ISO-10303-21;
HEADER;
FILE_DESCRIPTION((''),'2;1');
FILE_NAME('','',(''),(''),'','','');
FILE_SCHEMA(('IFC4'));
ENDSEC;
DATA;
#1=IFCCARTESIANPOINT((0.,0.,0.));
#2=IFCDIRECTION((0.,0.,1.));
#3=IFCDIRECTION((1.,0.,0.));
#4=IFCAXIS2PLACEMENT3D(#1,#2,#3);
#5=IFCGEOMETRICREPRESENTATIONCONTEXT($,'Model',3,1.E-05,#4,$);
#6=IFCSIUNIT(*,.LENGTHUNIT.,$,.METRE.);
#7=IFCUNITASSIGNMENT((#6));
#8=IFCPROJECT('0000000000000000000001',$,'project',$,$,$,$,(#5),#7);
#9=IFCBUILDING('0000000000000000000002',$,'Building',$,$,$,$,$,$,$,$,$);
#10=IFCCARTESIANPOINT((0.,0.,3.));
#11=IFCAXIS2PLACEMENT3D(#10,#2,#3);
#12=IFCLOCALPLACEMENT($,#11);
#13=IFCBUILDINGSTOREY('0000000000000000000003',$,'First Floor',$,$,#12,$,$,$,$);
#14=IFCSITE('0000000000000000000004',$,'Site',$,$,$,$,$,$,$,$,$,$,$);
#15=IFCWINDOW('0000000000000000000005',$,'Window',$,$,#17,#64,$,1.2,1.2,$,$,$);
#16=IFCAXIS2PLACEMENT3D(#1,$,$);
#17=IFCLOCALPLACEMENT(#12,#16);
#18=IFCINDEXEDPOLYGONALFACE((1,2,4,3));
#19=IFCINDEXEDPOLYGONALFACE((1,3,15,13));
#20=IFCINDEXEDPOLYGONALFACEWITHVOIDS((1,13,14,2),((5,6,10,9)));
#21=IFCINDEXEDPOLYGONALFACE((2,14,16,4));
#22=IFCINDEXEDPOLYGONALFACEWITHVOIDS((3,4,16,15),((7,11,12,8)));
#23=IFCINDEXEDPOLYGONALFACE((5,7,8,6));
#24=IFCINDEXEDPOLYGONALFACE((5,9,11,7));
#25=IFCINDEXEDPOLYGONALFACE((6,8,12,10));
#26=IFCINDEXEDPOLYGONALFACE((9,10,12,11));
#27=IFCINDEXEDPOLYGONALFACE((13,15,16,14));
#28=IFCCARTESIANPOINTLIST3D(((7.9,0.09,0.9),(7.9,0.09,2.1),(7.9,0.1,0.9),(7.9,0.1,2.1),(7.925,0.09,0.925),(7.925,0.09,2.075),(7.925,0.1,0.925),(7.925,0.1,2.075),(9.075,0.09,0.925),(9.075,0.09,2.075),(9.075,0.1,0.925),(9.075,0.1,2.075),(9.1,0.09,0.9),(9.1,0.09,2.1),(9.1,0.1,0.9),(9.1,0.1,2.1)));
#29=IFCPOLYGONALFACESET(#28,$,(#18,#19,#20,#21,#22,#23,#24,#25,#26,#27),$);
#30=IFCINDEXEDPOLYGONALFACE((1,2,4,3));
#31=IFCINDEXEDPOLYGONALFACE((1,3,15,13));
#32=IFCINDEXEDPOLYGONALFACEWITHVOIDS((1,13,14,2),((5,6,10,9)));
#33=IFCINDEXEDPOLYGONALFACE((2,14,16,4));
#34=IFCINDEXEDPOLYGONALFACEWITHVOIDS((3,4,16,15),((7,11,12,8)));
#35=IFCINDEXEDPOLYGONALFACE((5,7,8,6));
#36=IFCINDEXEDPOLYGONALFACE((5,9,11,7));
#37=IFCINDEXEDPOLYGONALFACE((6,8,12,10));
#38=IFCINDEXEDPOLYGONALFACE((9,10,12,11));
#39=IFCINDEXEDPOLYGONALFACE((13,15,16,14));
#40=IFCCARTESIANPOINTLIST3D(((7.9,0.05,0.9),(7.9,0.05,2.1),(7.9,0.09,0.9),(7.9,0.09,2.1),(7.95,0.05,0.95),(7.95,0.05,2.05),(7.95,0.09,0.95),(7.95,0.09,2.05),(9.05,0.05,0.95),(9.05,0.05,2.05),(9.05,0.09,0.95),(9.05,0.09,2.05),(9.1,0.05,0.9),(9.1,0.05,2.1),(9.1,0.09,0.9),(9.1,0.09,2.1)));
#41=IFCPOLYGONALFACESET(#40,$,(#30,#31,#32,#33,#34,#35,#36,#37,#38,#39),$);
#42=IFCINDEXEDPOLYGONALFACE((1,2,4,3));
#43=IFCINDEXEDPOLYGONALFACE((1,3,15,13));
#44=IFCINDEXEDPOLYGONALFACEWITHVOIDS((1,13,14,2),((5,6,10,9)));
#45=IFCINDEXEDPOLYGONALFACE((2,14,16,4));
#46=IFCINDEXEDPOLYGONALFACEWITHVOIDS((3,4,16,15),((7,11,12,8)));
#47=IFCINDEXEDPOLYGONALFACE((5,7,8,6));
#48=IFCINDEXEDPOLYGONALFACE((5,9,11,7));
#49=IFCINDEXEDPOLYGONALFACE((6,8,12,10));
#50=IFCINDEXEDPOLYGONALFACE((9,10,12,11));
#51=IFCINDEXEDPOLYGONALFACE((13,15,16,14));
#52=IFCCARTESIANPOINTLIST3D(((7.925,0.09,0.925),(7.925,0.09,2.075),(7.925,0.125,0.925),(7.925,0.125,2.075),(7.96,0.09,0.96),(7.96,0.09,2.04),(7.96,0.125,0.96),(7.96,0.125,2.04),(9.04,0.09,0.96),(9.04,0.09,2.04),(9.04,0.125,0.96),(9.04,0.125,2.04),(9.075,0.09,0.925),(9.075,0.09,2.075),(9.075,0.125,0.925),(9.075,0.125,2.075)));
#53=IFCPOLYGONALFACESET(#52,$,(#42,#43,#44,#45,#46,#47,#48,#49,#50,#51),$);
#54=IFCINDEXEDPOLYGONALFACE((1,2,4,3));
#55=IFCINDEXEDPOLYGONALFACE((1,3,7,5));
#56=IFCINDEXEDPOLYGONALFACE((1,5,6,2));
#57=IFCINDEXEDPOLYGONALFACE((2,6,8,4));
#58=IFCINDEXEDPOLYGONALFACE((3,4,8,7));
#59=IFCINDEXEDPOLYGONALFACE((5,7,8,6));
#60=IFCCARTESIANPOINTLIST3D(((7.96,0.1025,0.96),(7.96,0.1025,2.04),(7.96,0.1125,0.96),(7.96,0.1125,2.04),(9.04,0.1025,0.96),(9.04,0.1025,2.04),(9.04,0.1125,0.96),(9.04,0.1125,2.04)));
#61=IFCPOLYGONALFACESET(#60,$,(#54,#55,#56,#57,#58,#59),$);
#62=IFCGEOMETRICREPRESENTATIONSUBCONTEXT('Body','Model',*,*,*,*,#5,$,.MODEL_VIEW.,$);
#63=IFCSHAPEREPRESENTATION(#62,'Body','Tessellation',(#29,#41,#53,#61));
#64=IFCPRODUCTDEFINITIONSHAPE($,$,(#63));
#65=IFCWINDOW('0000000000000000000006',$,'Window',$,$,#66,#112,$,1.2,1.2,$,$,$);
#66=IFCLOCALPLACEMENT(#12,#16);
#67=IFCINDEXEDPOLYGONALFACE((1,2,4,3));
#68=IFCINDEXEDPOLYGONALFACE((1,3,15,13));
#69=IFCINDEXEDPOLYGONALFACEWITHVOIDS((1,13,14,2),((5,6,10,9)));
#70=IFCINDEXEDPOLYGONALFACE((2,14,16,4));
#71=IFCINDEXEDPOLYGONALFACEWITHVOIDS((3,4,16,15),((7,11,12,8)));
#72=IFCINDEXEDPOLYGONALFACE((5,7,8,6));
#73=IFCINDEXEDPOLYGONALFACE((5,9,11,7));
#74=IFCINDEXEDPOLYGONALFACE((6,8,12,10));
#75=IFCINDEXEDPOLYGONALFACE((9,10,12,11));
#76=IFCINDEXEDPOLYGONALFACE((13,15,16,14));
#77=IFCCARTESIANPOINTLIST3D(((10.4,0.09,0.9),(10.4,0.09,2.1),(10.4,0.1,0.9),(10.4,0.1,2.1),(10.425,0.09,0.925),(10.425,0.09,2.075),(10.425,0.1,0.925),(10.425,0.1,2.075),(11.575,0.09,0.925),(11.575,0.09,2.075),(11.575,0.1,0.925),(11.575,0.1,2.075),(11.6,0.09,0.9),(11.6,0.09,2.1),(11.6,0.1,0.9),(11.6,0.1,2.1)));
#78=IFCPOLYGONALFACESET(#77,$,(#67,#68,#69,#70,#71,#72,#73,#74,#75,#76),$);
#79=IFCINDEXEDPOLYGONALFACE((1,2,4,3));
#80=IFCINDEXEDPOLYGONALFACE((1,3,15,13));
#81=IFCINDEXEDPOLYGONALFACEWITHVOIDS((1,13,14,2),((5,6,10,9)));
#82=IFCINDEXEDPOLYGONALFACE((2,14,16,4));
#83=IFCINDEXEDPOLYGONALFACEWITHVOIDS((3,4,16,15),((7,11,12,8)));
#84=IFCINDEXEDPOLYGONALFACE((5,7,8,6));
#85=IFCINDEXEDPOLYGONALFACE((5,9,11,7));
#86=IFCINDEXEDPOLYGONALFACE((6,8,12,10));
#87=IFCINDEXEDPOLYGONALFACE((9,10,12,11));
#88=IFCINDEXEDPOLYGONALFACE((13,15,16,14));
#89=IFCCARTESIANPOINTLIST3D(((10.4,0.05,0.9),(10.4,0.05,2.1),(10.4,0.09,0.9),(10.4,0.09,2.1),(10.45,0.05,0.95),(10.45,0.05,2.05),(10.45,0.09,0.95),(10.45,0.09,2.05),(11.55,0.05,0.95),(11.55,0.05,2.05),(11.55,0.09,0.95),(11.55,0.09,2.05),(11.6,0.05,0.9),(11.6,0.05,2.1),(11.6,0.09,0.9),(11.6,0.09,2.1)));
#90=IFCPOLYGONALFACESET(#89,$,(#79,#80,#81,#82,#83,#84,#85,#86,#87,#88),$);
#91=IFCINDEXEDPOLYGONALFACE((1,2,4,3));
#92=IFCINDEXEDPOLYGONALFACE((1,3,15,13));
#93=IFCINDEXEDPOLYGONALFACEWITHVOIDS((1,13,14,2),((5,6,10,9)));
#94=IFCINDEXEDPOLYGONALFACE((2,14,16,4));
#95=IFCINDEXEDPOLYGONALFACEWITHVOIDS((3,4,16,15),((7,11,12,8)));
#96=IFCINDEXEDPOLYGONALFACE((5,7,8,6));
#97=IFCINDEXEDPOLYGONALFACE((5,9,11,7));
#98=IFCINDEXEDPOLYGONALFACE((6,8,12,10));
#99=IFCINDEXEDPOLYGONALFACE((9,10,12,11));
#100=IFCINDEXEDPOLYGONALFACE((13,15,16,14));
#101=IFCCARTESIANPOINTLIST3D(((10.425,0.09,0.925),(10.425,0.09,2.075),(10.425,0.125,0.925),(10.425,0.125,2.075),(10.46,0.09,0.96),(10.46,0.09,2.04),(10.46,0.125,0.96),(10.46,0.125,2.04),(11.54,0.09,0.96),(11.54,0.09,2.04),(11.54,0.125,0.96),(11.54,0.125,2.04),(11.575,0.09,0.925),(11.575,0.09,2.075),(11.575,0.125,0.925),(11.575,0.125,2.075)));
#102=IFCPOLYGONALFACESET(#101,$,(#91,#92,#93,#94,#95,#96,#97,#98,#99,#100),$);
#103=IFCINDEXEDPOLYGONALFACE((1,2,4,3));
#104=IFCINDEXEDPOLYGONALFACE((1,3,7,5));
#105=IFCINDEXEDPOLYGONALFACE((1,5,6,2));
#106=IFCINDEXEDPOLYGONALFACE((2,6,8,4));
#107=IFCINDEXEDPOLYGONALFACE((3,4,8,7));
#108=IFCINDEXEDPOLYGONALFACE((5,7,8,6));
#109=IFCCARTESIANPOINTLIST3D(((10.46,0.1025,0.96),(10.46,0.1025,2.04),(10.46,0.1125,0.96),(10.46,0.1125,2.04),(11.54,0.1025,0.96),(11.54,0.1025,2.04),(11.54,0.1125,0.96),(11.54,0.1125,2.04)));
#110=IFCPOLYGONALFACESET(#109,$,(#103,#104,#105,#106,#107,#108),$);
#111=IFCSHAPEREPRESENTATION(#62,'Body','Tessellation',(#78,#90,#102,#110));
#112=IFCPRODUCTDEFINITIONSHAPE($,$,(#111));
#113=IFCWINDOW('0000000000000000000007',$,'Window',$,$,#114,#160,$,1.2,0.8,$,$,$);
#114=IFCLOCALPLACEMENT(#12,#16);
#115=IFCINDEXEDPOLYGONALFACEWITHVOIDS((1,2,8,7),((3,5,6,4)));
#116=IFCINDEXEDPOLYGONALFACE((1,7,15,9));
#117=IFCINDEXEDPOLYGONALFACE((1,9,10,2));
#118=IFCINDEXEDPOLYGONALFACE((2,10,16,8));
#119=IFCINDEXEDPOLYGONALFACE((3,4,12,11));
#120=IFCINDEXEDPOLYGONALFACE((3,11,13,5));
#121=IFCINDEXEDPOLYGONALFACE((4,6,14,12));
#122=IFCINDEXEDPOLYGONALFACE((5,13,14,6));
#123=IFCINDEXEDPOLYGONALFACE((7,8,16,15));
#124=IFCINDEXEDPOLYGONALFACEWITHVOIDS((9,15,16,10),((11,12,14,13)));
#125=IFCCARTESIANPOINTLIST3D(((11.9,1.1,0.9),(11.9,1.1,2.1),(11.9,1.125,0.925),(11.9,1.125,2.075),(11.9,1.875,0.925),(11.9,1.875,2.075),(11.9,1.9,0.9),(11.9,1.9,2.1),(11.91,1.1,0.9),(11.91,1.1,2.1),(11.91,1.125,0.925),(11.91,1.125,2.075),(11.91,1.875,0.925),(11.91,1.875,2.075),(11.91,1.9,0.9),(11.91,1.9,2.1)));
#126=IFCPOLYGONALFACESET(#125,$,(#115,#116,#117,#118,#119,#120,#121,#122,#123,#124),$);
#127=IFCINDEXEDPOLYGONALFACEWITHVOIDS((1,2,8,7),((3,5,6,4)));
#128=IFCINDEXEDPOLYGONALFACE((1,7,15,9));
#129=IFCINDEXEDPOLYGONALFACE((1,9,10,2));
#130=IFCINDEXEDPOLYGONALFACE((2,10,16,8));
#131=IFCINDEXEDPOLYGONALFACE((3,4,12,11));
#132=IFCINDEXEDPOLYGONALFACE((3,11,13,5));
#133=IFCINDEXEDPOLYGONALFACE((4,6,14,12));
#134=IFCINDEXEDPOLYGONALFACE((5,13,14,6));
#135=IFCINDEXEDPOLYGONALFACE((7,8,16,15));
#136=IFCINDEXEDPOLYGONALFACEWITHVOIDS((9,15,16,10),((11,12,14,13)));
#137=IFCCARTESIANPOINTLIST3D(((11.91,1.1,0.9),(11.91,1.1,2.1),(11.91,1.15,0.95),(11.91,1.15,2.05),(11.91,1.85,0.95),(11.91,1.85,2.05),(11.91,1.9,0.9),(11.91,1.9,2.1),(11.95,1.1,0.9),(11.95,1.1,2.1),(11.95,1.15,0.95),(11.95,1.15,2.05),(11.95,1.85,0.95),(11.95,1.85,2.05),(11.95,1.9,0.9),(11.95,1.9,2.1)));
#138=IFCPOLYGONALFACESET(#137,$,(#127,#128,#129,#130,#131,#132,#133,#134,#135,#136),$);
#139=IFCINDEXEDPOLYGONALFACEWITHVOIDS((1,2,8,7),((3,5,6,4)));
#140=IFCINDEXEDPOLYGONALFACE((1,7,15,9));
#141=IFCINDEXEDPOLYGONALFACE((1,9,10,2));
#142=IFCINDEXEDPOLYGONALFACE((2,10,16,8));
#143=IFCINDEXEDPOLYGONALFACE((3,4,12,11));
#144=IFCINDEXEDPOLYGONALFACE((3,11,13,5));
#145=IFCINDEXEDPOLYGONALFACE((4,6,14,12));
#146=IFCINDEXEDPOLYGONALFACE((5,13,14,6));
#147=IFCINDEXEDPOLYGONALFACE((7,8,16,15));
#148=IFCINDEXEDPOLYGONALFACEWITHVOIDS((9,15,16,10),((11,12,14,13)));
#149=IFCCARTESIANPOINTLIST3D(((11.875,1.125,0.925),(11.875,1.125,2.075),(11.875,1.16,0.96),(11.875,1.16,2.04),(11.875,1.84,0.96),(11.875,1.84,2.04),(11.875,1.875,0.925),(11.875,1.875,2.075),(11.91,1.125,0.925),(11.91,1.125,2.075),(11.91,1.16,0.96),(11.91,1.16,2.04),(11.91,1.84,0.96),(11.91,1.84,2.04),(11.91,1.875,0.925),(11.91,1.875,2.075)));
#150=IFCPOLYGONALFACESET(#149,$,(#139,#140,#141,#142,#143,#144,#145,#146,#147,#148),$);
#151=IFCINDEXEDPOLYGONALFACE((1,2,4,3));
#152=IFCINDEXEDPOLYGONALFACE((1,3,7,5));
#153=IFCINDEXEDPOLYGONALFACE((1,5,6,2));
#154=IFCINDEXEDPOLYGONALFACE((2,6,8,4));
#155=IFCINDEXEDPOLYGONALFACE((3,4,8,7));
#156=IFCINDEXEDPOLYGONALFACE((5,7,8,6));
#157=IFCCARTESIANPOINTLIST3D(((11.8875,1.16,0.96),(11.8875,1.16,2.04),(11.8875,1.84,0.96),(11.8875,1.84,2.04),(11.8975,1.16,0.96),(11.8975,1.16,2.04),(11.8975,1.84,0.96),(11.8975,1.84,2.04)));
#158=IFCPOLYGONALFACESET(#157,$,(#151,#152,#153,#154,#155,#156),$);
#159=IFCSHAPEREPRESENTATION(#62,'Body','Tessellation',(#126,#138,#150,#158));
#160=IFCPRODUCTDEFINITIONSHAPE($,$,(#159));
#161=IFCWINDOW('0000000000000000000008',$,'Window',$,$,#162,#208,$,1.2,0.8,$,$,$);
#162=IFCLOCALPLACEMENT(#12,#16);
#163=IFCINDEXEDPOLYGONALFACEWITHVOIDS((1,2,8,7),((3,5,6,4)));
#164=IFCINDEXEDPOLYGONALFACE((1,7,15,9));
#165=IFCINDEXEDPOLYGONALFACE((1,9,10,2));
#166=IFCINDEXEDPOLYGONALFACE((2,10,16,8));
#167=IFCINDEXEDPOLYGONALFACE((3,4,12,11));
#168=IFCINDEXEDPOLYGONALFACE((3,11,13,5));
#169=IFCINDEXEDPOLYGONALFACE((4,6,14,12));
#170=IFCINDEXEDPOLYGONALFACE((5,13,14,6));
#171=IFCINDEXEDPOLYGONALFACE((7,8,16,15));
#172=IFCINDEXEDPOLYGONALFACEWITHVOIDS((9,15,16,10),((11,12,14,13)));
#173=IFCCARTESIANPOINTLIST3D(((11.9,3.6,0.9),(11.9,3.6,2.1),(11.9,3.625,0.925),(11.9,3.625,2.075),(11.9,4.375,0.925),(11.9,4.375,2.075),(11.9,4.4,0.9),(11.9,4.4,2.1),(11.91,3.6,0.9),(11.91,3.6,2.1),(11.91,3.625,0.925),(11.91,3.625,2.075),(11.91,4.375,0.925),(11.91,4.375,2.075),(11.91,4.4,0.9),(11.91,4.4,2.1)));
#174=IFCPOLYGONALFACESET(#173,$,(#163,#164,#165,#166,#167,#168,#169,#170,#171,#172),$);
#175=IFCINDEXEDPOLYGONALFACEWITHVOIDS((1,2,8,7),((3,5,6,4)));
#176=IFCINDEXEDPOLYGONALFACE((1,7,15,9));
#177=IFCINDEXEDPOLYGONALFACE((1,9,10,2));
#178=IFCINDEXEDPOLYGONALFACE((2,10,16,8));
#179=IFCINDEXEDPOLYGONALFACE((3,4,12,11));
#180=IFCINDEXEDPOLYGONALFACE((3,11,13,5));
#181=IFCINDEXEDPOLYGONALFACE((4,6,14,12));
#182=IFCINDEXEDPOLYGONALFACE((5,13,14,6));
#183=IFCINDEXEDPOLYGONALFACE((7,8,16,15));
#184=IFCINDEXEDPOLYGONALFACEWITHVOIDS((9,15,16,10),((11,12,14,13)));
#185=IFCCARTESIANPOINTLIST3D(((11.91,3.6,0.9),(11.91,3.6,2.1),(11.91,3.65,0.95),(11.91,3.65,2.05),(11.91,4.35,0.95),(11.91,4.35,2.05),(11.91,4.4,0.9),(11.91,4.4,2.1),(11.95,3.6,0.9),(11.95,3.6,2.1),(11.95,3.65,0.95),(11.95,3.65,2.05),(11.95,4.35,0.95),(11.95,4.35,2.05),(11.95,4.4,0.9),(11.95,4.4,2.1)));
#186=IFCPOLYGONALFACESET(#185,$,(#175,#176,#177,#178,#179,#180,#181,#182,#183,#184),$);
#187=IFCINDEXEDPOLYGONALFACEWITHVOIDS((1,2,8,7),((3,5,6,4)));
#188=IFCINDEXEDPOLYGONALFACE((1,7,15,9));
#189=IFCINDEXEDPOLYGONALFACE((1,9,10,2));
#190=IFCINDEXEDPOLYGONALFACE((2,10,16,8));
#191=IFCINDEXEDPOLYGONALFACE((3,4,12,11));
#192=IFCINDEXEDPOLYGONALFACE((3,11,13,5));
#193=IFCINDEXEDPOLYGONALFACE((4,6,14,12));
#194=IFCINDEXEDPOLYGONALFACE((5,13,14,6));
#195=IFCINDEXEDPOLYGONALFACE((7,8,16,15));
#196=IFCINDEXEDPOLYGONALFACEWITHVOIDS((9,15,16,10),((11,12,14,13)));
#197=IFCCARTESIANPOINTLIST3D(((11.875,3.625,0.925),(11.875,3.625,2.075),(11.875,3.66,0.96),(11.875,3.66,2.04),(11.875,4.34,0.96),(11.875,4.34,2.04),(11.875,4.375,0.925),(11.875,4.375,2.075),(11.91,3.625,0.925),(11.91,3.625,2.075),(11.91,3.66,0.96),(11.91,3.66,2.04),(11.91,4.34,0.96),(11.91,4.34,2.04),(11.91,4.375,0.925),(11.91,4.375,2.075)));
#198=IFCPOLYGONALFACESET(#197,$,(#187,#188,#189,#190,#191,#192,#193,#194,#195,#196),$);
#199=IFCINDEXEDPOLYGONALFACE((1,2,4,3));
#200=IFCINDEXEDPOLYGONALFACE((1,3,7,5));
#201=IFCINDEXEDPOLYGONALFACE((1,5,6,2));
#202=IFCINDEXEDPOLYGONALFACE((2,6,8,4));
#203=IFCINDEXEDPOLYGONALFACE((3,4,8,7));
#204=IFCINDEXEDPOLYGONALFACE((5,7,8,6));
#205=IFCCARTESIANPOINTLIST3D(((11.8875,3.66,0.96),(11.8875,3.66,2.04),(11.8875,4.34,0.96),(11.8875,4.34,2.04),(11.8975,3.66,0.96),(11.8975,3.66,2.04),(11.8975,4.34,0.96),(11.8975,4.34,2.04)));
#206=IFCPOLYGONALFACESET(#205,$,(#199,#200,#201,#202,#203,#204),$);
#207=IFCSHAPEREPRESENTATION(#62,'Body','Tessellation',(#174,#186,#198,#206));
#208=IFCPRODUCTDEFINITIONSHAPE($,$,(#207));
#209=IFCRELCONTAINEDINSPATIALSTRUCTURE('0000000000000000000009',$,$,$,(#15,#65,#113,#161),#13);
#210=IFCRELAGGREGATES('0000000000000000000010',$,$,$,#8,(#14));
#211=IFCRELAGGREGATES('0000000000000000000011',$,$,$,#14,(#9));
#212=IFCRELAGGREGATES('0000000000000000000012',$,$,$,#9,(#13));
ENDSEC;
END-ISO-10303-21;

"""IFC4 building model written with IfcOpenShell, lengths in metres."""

from ifc_helpers import new_model, si_unit, frame, origin_with_axes, place, context, subcontext, project, spatial, line, indexed_curve, outline, extrude, element, save


model = new_model("IFC4")

# Units and contexts
model_context = context("Model", 3, precision=1e-05, world=origin_with_axes())
body_context = subcontext(model_context, "Body", "Model", "MODEL_VIEW")
ifc_project = project(units=[si_unit("LENGTHUNIT", "METRE")], contexts=[model_context])

# Site, building, storey
site = spatial("IfcSite", under=ifc_project, Name="Site")
building = spatial("IfcBuilding", under=site, Name="Building")
storey_placement = place(None, frame((0.0, 0.0, 3.0), z_axis=(0.0, 0.0, 1.0), x_axis=(1.0, 0.0, 0.0)))
storey = spatial("IfcBuildingStorey", under=building, at=storey_placement, Name="First Floor")

# Windows
for number, where, z_axis, x_axis, name in (
    (1, (7.9, 0.0, 0.9), (0.0, 0.0, 1.0), (1.0, 0.0, 0.0), "Window"),
    (2, (10.4, 0.0, 0.9), (0.0, 0.0, 1.0), (1.0, 0.0, 0.0), "Window"),
):
    element("IfcWindow", number, at=place(storey_placement, frame(where, z_axis=z_axis, x_axis=x_axis)), inside=storey, Name=name, OverallHeight=1.2, OverallWidth=1.2, context=body_context, shape_type="SweptSolid", body=[
        extrude(outline(indexed_curve([(0.0, 0.0), (1.2, 0.0), (1.2, 1.2), (0.0, 1.2)], segments=[line(1, 2, 3, 4, 1)]), holes=[indexed_curve([(0.025, 0.025), (1.175, 0.025), (1.175, 1.175), (0.025, 1.175)], segments=[line(1, 2, 3, 4, 1)])]), frame((0.0, 0.09, 0.0), z_axis=(0.0, -1.0, 0.0), x_axis=(1.0, 0.0, 0.0)), (0.0, 0.0, -1.0), 0.01),
        extrude(outline(indexed_curve([(0.0, 0.0), (1.2, 0.0), (1.2, 1.2), (0.0, 1.2)], segments=[line(1, 2, 3, 4, 1)]), holes=[indexed_curve([(0.05, 0.05), (1.15, 0.05), (1.15, 1.15), (0.05, 1.15)], segments=[line(1, 2, 3, 4, 1)])]), frame((0.0, 0.05, 0.0), z_axis=(0.0, -1.0, 0.0), x_axis=(1.0, 0.0, 0.0)), (0.0, 0.0, -1.0), 0.04),
        extrude(outline(indexed_curve([(0.0, 0.0), (1.15, 0.0), (1.15, 1.15), (0.0, 1.15)], segments=[line(1, 2, 3, 4, 1)]), holes=[indexed_curve([(0.035, 0.035), (1.115, 0.035), (1.115, 1.115), (0.035, 1.115)], segments=[line(1, 2, 3, 4, 1)])]), frame((0.025, 0.09, 0.025), z_axis=(0.0, -1.0, 0.0), x_axis=(1.0, 0.0, 0.0)), (0.0, 0.0, -1.0), 0.035),
        extrude(outline(indexed_curve([(0.035, 0.035), (1.115, 0.035), (1.115, 1.115), (0.035, 1.115)], segments=[line(1, 2, 3, 4, 1)])), frame((0.025, 0.1025, 0.025), z_axis=(0.0, -1.0, 0.0), x_axis=(1.0, 0.0, 0.0)), (0.0, 0.0, -1.0), 0.01),
    ])
for number, where, z_axis, x_axis, name in (
    (3, (12.0, 1.1, 0.9), (0.0, 0.0, 1.0), (0.0, 1.0, 0.0), "Window"),
    (4, (12.0, 3.6, 0.9), (0.0, 0.0, 1.0), (0.0, 1.0, 0.0), "Window"),
):
    element("IfcWindow", number, at=place(storey_placement, frame(where, z_axis=z_axis, x_axis=x_axis)), inside=storey, Name=name, OverallHeight=1.2, OverallWidth=0.8, context=body_context, shape_type="SweptSolid", body=[
        extrude(outline(indexed_curve([(0.0, 0.0), (0.8, 0.0), (0.8, 1.2), (0.0, 1.2)], segments=[line(1, 2, 3, 4, 1)]), holes=[indexed_curve([(0.025, 0.025), (0.775, 0.025), (0.775, 1.175), (0.025, 1.175)], segments=[line(1, 2, 3, 4, 1)])]), frame((0.0, 0.09, 0.0), z_axis=(0.0, -1.0, 0.0), x_axis=(1.0, 0.0, 0.0)), (0.0, 0.0, -1.0), 0.01),
        extrude(outline(indexed_curve([(0.0, 0.0), (0.8, 0.0), (0.8, 1.2), (0.0, 1.2)], segments=[line(1, 2, 3, 4, 1)]), holes=[indexed_curve([(0.05, 0.05), (0.75, 0.05), (0.75, 1.15), (0.05, 1.15)], segments=[line(1, 2, 3, 4, 1)])]), frame((0.0, 0.05, 0.0), z_axis=(0.0, -1.0, 0.0), x_axis=(1.0, 0.0, 0.0)), (0.0, 0.0, -1.0), 0.04),
        extrude(outline(indexed_curve([(0.0, 0.0), (0.75, 0.0), (0.75, 1.15), (0.0, 1.15)], segments=[line(1, 2, 3, 4, 1)]), holes=[indexed_curve([(0.035, 0.035), (0.715, 0.035), (0.715, 1.115), (0.035, 1.115)], segments=[line(1, 2, 3, 4, 1)])]), frame((0.025, 0.09, 0.025), z_axis=(0.0, -1.0, 0.0), x_axis=(1.0, 0.0, 0.0)), (0.0, 0.0, -1.0), 0.035),
        extrude(outline(indexed_curve([(0.035, 0.035), (0.715, 0.035), (0.715, 1.115), (0.035, 1.115)], segments=[line(1, 2, 3, 4, 1)])), frame((0.025, 0.1025, 0.025), z_axis=(0.0, -1.0, 0.0), x_axis=(1.0, 0.0, 0.0)), (0.0, 0.0, -1.0), 0.01),
    ])

save(model, "model.ifc")
